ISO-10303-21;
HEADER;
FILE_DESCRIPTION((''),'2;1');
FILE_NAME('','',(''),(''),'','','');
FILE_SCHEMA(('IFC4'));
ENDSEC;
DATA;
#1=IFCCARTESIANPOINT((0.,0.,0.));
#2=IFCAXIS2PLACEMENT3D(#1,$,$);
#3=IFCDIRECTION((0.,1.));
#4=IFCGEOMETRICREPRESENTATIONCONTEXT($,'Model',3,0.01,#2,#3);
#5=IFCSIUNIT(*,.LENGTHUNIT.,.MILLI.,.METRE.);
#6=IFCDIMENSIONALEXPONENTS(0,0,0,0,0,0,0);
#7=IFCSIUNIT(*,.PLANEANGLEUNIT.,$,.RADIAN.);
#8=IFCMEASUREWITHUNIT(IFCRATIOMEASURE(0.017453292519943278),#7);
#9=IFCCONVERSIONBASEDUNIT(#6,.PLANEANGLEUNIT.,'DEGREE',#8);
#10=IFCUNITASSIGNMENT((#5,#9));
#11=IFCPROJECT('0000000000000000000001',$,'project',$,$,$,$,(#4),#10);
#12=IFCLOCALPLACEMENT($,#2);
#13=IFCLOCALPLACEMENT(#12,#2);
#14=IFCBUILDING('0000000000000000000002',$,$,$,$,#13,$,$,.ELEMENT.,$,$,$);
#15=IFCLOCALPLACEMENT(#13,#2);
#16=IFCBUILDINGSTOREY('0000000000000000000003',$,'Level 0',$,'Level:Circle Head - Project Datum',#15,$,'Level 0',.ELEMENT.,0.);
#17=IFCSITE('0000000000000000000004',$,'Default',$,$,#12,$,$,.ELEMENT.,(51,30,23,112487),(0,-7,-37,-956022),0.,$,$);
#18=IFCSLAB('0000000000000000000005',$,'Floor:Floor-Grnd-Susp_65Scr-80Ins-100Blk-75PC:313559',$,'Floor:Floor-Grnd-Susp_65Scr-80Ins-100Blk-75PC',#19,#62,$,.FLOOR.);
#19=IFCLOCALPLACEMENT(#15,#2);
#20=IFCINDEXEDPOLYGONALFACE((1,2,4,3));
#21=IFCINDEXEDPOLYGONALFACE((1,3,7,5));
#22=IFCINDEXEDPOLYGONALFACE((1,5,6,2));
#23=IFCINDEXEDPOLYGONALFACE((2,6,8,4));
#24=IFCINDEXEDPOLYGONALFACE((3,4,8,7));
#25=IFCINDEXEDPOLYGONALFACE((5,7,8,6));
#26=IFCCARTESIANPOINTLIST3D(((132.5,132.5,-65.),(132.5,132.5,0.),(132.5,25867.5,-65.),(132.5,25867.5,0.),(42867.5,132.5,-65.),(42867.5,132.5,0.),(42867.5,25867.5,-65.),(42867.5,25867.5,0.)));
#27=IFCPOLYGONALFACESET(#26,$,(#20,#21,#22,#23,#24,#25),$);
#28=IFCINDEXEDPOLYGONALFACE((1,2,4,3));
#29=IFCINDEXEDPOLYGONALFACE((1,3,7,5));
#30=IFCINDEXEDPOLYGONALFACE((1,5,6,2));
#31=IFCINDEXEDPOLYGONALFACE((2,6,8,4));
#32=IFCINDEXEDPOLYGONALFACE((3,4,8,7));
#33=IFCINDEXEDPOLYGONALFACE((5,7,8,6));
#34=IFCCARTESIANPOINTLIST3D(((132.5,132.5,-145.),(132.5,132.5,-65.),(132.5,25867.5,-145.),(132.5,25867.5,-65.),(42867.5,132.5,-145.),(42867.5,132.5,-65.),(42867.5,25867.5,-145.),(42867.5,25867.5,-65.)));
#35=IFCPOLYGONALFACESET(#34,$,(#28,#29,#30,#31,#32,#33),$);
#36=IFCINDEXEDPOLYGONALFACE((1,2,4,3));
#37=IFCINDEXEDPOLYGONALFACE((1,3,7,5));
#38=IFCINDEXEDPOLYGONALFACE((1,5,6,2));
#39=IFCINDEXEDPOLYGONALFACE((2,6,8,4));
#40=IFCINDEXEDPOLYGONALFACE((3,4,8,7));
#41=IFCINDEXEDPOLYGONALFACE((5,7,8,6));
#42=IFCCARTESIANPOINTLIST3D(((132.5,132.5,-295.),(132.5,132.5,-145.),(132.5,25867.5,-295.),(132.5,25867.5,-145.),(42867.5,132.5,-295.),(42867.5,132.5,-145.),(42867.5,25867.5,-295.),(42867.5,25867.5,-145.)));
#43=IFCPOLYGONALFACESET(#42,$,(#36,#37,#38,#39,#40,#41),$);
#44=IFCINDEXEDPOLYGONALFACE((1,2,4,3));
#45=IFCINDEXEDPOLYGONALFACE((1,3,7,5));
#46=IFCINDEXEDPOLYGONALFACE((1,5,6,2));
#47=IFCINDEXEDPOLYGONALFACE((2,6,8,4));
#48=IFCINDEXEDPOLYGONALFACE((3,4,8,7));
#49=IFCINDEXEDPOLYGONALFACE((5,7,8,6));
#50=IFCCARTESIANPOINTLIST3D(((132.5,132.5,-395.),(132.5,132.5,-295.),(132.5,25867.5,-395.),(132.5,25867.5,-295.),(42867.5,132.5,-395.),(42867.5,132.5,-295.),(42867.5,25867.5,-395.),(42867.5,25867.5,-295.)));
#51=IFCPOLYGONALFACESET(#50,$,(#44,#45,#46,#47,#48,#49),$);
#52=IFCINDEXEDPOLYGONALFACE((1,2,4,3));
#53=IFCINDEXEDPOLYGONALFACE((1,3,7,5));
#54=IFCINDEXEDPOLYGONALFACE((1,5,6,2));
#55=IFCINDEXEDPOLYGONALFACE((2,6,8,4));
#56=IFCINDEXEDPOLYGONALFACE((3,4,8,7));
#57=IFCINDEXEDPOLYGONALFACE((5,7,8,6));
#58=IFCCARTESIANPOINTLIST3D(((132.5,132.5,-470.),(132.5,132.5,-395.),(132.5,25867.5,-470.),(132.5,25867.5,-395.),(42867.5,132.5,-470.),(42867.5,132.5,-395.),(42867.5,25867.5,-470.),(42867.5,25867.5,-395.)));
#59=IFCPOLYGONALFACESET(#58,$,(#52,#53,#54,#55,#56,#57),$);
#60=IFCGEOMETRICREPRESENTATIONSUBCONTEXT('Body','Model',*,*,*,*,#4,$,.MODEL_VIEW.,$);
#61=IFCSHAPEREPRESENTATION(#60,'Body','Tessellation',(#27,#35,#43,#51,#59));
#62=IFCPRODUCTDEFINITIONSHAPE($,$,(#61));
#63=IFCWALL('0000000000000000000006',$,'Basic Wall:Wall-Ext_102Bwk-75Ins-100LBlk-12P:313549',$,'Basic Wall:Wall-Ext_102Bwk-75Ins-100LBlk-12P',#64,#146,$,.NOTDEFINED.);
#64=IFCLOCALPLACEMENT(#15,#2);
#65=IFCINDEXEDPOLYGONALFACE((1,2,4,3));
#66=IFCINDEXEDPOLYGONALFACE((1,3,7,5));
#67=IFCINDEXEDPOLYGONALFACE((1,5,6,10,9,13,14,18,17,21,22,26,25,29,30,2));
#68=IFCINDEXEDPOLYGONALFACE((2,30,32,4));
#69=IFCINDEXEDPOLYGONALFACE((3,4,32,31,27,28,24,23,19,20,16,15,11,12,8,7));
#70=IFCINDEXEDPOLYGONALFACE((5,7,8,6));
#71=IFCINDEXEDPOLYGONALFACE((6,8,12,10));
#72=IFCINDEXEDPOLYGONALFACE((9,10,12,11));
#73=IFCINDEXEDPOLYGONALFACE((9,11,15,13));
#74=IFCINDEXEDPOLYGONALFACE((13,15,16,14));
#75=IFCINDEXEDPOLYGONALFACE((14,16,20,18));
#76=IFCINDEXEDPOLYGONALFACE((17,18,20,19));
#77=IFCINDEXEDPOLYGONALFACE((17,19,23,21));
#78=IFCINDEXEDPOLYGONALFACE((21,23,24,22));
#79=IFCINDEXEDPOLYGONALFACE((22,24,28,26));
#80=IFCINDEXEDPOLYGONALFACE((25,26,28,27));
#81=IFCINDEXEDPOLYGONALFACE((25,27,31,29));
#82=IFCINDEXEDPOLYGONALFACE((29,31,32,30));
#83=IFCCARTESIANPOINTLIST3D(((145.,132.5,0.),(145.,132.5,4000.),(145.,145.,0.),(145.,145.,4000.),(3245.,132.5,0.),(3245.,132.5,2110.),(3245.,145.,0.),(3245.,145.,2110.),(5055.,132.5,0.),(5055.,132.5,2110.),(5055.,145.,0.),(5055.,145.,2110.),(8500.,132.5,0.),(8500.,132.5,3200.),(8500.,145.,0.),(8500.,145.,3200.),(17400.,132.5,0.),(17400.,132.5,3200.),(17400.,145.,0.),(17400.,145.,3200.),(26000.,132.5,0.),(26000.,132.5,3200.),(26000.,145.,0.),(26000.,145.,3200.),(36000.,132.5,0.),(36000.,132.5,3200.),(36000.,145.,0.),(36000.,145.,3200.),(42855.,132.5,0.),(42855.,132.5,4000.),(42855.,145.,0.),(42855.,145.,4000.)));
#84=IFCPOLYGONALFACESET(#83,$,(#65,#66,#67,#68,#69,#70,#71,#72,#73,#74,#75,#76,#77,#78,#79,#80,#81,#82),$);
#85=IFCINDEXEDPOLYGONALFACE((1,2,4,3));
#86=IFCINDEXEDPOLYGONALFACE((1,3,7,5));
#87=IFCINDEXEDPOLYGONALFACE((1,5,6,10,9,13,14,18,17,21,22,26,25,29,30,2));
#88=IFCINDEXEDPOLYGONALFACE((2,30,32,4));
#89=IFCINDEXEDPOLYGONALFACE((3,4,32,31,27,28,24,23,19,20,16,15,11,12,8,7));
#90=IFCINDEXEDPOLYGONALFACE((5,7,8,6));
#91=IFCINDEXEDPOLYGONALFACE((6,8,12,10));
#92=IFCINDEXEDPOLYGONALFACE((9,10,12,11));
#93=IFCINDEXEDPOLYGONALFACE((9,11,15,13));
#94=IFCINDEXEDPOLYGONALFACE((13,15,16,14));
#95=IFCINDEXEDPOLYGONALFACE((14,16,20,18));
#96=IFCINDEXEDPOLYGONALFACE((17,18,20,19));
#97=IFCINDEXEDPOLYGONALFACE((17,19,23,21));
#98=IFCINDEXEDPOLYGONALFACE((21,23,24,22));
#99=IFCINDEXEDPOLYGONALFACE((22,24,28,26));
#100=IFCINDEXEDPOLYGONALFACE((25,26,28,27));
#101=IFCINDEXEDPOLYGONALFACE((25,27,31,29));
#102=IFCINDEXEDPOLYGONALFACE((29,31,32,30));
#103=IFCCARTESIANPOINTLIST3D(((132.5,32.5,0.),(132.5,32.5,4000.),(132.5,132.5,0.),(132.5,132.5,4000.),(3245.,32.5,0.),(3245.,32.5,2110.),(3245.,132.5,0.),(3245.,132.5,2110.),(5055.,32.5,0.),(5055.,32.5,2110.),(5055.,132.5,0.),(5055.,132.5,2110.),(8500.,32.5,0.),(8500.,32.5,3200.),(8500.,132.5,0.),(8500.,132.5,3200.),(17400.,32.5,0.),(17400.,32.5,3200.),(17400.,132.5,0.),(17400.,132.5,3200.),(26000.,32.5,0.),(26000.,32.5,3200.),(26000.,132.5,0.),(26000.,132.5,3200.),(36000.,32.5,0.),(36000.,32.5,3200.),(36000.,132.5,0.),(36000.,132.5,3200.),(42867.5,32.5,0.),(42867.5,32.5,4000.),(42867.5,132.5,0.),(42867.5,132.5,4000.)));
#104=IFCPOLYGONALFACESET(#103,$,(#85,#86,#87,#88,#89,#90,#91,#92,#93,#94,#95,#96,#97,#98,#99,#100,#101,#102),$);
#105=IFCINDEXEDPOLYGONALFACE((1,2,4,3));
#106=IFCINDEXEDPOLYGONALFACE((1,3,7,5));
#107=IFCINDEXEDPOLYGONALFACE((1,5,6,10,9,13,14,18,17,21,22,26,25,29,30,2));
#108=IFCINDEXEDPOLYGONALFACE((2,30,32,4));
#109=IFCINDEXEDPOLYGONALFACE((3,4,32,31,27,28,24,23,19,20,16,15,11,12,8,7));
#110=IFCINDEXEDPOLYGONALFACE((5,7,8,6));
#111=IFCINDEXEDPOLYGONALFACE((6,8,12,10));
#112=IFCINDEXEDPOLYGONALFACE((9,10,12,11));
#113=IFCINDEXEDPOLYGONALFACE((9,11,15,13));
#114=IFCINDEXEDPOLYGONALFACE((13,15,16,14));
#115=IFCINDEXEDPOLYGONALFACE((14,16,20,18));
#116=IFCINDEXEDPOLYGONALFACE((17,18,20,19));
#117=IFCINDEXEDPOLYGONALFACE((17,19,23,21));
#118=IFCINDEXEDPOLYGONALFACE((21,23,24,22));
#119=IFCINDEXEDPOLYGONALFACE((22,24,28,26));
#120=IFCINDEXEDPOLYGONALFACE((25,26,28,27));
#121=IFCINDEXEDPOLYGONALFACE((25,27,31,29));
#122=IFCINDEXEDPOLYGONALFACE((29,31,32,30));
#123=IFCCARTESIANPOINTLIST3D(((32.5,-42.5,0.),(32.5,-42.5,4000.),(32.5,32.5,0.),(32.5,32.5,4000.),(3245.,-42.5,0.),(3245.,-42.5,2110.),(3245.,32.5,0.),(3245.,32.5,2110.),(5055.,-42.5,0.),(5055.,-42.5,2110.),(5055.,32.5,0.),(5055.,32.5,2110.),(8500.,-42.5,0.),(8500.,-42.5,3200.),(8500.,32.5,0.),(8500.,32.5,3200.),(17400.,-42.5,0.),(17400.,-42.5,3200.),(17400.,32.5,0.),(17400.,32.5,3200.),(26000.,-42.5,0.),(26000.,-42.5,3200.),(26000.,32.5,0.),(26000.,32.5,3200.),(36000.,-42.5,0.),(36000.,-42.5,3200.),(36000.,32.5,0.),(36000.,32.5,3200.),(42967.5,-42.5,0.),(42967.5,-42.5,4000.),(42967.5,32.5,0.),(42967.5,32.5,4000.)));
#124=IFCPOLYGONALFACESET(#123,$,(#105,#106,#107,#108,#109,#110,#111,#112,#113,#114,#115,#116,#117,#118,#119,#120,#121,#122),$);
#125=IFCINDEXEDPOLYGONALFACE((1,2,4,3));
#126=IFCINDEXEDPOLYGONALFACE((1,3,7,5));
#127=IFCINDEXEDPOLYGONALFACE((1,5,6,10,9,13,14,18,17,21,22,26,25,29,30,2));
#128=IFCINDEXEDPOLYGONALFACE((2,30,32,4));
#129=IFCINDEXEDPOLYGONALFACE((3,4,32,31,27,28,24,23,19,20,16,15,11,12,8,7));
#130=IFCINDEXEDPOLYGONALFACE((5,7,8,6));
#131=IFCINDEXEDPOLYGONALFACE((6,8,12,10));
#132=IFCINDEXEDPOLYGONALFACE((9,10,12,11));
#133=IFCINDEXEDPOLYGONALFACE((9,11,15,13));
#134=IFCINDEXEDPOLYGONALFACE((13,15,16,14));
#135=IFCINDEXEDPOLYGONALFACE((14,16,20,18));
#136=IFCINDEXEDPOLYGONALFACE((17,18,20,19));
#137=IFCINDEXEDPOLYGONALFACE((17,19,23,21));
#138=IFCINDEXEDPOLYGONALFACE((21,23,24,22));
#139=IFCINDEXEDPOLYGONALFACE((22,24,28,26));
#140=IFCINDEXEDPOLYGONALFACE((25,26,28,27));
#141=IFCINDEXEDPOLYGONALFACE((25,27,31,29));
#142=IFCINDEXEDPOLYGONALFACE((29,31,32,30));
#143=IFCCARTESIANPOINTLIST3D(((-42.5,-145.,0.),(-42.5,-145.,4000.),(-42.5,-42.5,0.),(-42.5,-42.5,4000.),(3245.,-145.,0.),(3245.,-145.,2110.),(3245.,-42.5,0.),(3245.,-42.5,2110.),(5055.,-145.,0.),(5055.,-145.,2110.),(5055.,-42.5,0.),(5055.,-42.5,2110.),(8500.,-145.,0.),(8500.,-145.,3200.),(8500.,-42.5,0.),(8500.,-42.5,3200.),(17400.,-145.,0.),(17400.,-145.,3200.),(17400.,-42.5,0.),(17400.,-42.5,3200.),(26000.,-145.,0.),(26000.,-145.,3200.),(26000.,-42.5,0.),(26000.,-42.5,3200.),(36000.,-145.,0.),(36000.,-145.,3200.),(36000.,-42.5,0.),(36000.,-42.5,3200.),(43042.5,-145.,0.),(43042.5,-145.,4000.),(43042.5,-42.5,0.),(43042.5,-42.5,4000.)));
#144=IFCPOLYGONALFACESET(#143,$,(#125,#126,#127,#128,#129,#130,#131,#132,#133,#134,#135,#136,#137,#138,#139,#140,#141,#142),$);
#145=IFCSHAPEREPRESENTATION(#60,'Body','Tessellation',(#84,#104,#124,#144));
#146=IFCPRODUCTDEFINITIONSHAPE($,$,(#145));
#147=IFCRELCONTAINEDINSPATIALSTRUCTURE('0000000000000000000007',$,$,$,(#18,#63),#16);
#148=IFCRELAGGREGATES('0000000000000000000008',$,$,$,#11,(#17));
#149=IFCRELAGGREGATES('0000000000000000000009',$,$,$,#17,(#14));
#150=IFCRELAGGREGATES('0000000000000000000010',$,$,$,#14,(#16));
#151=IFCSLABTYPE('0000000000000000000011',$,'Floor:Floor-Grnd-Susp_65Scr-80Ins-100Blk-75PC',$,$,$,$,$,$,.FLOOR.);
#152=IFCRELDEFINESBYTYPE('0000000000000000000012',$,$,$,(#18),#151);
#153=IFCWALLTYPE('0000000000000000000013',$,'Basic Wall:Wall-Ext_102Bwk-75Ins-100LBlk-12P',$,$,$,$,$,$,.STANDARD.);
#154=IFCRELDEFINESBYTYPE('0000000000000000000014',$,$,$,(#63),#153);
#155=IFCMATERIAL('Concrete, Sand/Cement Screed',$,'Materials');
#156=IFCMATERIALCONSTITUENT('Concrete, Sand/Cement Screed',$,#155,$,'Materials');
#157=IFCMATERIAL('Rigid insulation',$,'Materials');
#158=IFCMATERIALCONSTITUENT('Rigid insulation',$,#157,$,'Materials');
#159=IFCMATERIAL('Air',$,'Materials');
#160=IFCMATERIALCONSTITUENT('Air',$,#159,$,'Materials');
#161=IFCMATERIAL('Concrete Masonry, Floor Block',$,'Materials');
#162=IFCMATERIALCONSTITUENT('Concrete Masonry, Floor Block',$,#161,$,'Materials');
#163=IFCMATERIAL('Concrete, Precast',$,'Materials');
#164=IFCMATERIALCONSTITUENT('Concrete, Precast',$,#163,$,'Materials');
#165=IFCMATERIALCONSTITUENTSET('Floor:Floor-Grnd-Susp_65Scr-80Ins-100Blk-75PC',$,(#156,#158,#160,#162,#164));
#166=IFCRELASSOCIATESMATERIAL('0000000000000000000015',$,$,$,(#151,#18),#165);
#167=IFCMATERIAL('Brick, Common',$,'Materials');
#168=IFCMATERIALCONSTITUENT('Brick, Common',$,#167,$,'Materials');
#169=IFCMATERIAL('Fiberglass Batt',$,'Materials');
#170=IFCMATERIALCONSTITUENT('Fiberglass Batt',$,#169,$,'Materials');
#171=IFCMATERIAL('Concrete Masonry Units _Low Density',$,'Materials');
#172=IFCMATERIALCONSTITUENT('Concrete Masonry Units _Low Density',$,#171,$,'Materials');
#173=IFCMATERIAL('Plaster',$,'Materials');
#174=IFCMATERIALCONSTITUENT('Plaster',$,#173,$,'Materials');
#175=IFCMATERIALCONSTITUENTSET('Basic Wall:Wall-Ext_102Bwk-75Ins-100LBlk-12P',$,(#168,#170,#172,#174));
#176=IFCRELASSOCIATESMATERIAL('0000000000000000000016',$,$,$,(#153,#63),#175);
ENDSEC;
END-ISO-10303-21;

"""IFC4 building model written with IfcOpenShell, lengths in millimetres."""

from ifc_helpers import new_model, entity, si_unit, converted_unit, direction, frame, origin, place, context, subcontext, project, spatial, indexed_curve, outline, extrude, material, constituent, constituent_set, type_object, element, save


model = new_model("IFC4")

# Units and contexts
model_context = context("Model", 3, precision=0.01, world=origin(), true_north=direction((0.0, 1.0)))
body_context = subcontext(model_context, "Body", "Model", "MODEL_VIEW")
ifc_project = project(units=[si_unit("LENGTHUNIT", "METRE", prefix="MILLI"), converted_unit("PLANEANGLEUNIT", "DEGREE", entity("IfcRatioMeasure", 0.017453292519943278), si_unit("PLANEANGLEUNIT", "RADIAN"), dimensions=[0, 0, 0, 0, 0, 0, 0])], contexts=[model_context])

# Site, building, storey
site_placement = place(None, origin())
site = spatial("IfcSite", under=ifc_project, at=site_placement, Name="Default", CompositionType="ELEMENT", RefLatitude=(51, 30, 23, 112487), RefLongitude=(0, -7, -37, -956022), RefElevation=0.0)
building_placement = place(site_placement, origin())
building = spatial("IfcBuilding", under=site, at=building_placement, CompositionType="ELEMENT")
storey_placement = place(building_placement, origin())
storey = spatial("IfcBuildingStorey", under=building, at=storey_placement, Name="Level 0", ObjectType="Level:Circle Head - Project Datum", LongName="Level 0", CompositionType="ELEMENT", Elevation=0.0)

# Slab
ifc_material_1 = material(Name="Concrete, Sand/Cement Screed", Category="Materials")
ifc_constituent_1 = constituent(ifc_material_1, Name="Concrete, Sand/Cement Screed", Category="Materials")
ifc_material_2 = material(Name="Rigid insulation", Category="Materials")
ifc_constituent_2 = constituent(ifc_material_2, Name="Rigid insulation", Category="Materials")
ifc_material_3 = material(Name="Air", Category="Materials")
ifc_constituent_3 = constituent(ifc_material_3, Name="Air", Category="Materials")
ifc_material_4 = material(Name="Concrete Masonry, Floor Block", Category="Materials")
ifc_constituent_4 = constituent(ifc_material_4, Name="Concrete Masonry, Floor Block", Category="Materials")
ifc_material_5 = material(Name="Concrete, Precast", Category="Materials")
ifc_constituent_5 = constituent(ifc_material_5, Name="Concrete, Precast", Category="Materials")
ifc_constituent_set_1 = constituent_set(constituents=[ifc_constituent_1, ifc_constituent_2, ifc_constituent_3, ifc_constituent_4, ifc_constituent_5], Name="Floor:Floor-Grnd-Susp_65Scr-80Ins-100Blk-75PC")
slab_type = type_object("IfcSlabType", Name="Floor:Floor-Grnd-Susp_65Scr-80Ins-100Blk-75PC", PredefinedType="FLOOR", material=ifc_constituent_set_1)
slab_placement = place(storey_placement, origin())
element("IfcSlab", 1, at=slab_placement, inside=storey, type_object=slab_type, material=ifc_constituent_set_1, Name="Floor:Floor-Grnd-Susp_65Scr-80Ins-100Blk-75PC:313559", ObjectType="Floor:Floor-Grnd-Susp_65Scr-80Ins-100Blk-75PC", PredefinedType="FLOOR", context=body_context, shape_type="SweptSolid", body=[
    extrude(outline(indexed_curve([(-21367.5, -12867.5), (21367.5, -12867.5), (21367.5, 12867.5), (-21367.5, 12867.5), (-21367.5, -12867.5)], self_intersect=False)), frame((21500.0, 13000.0, -65.0), z_axis=(0.0, 0.0, 1.0), x_axis=(-1.0, 0.0, 0.0)), (0.0, 0.0, 1.0), 65.0),
    extrude(outline(indexed_curve([(-21367.5, -12867.5), (21367.5, -12867.5), (21367.5, 12867.5), (-21367.5, 12867.5), (-21367.5, -12867.5)], self_intersect=False)), frame((21500.0, 13000.0, -145.0), z_axis=(0.0, 0.0, 1.0), x_axis=(-1.0, 0.0, 0.0)), (0.0, 0.0, 1.0), 80.0),
    extrude(outline(indexed_curve([(-21367.5, -12867.5), (21367.5, -12867.5), (21367.5, 12867.5), (-21367.5, 12867.5), (-21367.5, -12867.5)], self_intersect=False)), frame((21500.0, 13000.0, -295.0), z_axis=(0.0, 0.0, 1.0), x_axis=(-1.0, 0.0, 0.0)), (0.0, 0.0, 1.0), 150.0),
    extrude(outline(indexed_curve([(-21367.5, -12867.5), (21367.5, -12867.5), (21367.5, 12867.5), (-21367.5, 12867.5), (-21367.5, -12867.5)], self_intersect=False)), frame((21500.0, 13000.0, -395.0), z_axis=(0.0, 0.0, 1.0), x_axis=(-1.0, 0.0, 0.0)), (0.0, 0.0, 1.0), 100.0),
    extrude(outline(indexed_curve([(-21367.5, -12867.5), (21367.5, -12867.5), (21367.5, 12867.5), (-21367.5, 12867.5), (-21367.5, -12867.5)], self_intersect=False)), frame((21500.0, 13000.0, -470.0), z_axis=(0.0, 0.0, 1.0), x_axis=(-1.0, 0.0, 0.0)), (0.0, 0.0, 1.0), 75.0),
])

# Shared definitions
ifc_material_6 = material(Name="Brick, Common", Category="Materials")
ifc_constituent_6 = constituent(ifc_material_6, Name="Brick, Common", Category="Materials")
ifc_material_7 = material(Name="Fiberglass Batt", Category="Materials")
ifc_constituent_7 = constituent(ifc_material_7, Name="Fiberglass Batt", Category="Materials")
ifc_material_8 = material(Name="Concrete Masonry Units _Low Density", Category="Materials")
ifc_constituent_8 = constituent(ifc_material_8, Name="Concrete Masonry Units _Low Density", Category="Materials")
ifc_material_9 = material(Name="Plaster", Category="Materials")
ifc_constituent_9 = constituent(ifc_material_9, Name="Plaster", Category="Materials")
ifc_constituent_set_2 = constituent_set(constituents=[ifc_constituent_6, ifc_constituent_7, ifc_constituent_8, ifc_constituent_9], Name="Basic Wall:Wall-Ext_102Bwk-75Ins-100LBlk-12P")
wall_type = type_object("IfcWallType", Name="Basic Wall:Wall-Ext_102Bwk-75Ins-100LBlk-12P", PredefinedType="STANDARD", material=ifc_constituent_set_2)

# Wall, openings
wall_1_placement = place(storey_placement, frame((42855.0, 0.0, 0.0), z_axis=(0.0, 0.0, 1.0), x_axis=(-1.0, 0.0, 0.0)))
wall_1 = element("IfcWall", 2, at=wall_1_placement, inside=storey, type_object=wall_type, material=ifc_constituent_set_2, Name="Basic Wall:Wall-Ext_102Bwk-75Ins-100LBlk-12P:313549", ObjectType="Basic Wall:Wall-Ext_102Bwk-75Ins-100LBlk-12P", PredefinedType="NOTDEFINED", context=body_context, shape_type="SweptSolid", body=[
    extrude(outline(indexed_curve([(-17255.0, -2436.2), (25455.0, -2436.2), (25455.0, 1563.8), (18600.0, 1563.8), (18600.0, -1636.2), (8600.0, -1636.3), (8600.0, 1563.8), (0.0, 1563.8), (0.0, -1636.3), (-8900.0, -1636.3), (-8900.0, 1563.8), (-12345.0, 1563.8), (-12345.0, -546.2), (-14155.0, -546.2), (-14155.0, 1563.8), (-17255.0, 1563.8), (-17255.0, -2436.2)], self_intersect=False)), frame((25455.0, -132.5, 1563.8), z_axis=(0.0, -1.0, 0.0), x_axis=(-1.0, 0.0, 0.0)), (0.0, 0.0, 1.0), 12.5),
    extrude(outline(indexed_curve([(-17267.5, -2436.2), (25467.5, -2436.2), (25467.5, 1563.8), (18600.0, 1563.8), (18600.0, -1636.2), (8600.0, -1636.3), (8600.0, 1563.8), (0.0, 1563.8), (0.0, -1636.3), (-8900.0, -1636.3), (-8900.0, 1563.8), (-12345.0, 1563.8), (-12345.0, -546.2), (-14155.0, -546.2), (-14155.0, 1563.8), (-17267.5, 1563.8), (-17267.5, -2436.2)], self_intersect=False)), frame((25455.0, -32.5, 1563.8), z_axis=(0.0, -1.0, 0.0), x_axis=(-1.0, 0.0, 0.0)), (0.0, 0.0, 1.0), 100.0),
    extrude(outline(indexed_curve([(-17367.5, -2436.2), (25567.5, -2436.2), (25567.5, 1563.8), (18600.0, 1563.8), (18600.0, -1636.2), (8600.0, -1636.3), (8600.0, 1563.8), (0.0, 1563.8), (0.0, -1636.3), (-8900.0, -1636.3), (-8900.0, 1563.8), (-12345.0, 1563.8), (-12345.0, -546.2), (-14155.0, -546.2), (-14155.0, 1563.8), (-17367.5, 1563.8), (-17367.5, -2436.2)], self_intersect=False)), frame((25455.0, 42.5, 1563.8), z_axis=(0.0, -1.0, 0.0), x_axis=(-1.0, 0.0, 0.0)), (0.0, 0.0, 1.0), 75.0),
    extrude(outline(indexed_curve([(-1563.8, -17442.5), (2436.2, -17442.5), (2436.2, 25642.5), (-1563.8, 25642.5), (-1563.8, 18600.0), (1636.2, 18600.0), (1636.3, 8600.0), (-1563.8, 8600.0), (-1563.8, 0.0), (1636.3, 0.0), (1636.3, -8900.0), (-1563.8, -8900.0), (-1563.8, -12345.0), (546.2, -12345.0), (546.2, -14155.0), (-1563.8, -14155.0), (-1563.8, -17442.5)], self_intersect=False)), frame((25455.0, 145.0, 1563.8), z_axis=(0.0, -1.0, 0.0), x_axis=(0.0, 0.0, 1.0)), (0.0, 0.0, 1.0), 102.5),
])
opening_1_placement = place(wall_1_placement, origin())
element("IfcOpeningElement", 3, at=opening_1_placement, cuts=wall_1, PredefinedType="OPENING", context=body_context, shape_type="SweptSolid", body=[
    extrude(outline(indexed_curve([(-5000.0, -1600.0), (5000.0, -1600.0), (5000.0, 1600.0), (-5000.0, 1600.0), (-5000.0, -1600.0)], self_intersect=False)), frame((11855.0, 145.0, 1600.0), z_axis=(0.0, -1.0, 0.0), x_axis=(1.0, 0.0, 0.0)), (0.0, 0.0, 1.0), 290.0),
])
opening_2_placement = place(wall_1_placement, origin())
element("IfcOpeningElement", 4, at=opening_2_placement, cuts=wall_1, PredefinedType="OPENING", context=body_context, shape_type="SweptSolid", body=[
    extrude(outline(indexed_curve([(-4450.0, -1600.0), (4450.0, -1600.0), (4450.0, 1600.0), (-4450.0, 1600.0), (-4450.0, -1600.0)], self_intersect=False)), frame((29905.0, 145.0, 1600.0), z_axis=(0.0, -1.0, 0.0), x_axis=(1.0, 0.0, 0.0)), (0.0, 0.0, 1.0), 290.0),
])
opening_3_placement = place(wall_1_placement, frame((39610.0, 145.0, 0.0)))
element("IfcOpeningElement", 5, at=opening_3_placement, cuts=wall_1, PredefinedType="OPENING", context=body_context, shape_type="SweptSolid", body=[
    extrude(outline(indexed_curve([(2110.0, 1810.0), (0.0, 1810.0), (0.0, 0.0), (2110.0, 0.0), (2110.0, 1810.0)], self_intersect=False)), frame((0.0, 0.0, 0.0), z_axis=(0.0, -1.0, 0.0), x_axis=(0.0, 0.0, 1.0)), (0.0, 0.0, 1.0), 290.0),
])

save(model, "model.ifc")
